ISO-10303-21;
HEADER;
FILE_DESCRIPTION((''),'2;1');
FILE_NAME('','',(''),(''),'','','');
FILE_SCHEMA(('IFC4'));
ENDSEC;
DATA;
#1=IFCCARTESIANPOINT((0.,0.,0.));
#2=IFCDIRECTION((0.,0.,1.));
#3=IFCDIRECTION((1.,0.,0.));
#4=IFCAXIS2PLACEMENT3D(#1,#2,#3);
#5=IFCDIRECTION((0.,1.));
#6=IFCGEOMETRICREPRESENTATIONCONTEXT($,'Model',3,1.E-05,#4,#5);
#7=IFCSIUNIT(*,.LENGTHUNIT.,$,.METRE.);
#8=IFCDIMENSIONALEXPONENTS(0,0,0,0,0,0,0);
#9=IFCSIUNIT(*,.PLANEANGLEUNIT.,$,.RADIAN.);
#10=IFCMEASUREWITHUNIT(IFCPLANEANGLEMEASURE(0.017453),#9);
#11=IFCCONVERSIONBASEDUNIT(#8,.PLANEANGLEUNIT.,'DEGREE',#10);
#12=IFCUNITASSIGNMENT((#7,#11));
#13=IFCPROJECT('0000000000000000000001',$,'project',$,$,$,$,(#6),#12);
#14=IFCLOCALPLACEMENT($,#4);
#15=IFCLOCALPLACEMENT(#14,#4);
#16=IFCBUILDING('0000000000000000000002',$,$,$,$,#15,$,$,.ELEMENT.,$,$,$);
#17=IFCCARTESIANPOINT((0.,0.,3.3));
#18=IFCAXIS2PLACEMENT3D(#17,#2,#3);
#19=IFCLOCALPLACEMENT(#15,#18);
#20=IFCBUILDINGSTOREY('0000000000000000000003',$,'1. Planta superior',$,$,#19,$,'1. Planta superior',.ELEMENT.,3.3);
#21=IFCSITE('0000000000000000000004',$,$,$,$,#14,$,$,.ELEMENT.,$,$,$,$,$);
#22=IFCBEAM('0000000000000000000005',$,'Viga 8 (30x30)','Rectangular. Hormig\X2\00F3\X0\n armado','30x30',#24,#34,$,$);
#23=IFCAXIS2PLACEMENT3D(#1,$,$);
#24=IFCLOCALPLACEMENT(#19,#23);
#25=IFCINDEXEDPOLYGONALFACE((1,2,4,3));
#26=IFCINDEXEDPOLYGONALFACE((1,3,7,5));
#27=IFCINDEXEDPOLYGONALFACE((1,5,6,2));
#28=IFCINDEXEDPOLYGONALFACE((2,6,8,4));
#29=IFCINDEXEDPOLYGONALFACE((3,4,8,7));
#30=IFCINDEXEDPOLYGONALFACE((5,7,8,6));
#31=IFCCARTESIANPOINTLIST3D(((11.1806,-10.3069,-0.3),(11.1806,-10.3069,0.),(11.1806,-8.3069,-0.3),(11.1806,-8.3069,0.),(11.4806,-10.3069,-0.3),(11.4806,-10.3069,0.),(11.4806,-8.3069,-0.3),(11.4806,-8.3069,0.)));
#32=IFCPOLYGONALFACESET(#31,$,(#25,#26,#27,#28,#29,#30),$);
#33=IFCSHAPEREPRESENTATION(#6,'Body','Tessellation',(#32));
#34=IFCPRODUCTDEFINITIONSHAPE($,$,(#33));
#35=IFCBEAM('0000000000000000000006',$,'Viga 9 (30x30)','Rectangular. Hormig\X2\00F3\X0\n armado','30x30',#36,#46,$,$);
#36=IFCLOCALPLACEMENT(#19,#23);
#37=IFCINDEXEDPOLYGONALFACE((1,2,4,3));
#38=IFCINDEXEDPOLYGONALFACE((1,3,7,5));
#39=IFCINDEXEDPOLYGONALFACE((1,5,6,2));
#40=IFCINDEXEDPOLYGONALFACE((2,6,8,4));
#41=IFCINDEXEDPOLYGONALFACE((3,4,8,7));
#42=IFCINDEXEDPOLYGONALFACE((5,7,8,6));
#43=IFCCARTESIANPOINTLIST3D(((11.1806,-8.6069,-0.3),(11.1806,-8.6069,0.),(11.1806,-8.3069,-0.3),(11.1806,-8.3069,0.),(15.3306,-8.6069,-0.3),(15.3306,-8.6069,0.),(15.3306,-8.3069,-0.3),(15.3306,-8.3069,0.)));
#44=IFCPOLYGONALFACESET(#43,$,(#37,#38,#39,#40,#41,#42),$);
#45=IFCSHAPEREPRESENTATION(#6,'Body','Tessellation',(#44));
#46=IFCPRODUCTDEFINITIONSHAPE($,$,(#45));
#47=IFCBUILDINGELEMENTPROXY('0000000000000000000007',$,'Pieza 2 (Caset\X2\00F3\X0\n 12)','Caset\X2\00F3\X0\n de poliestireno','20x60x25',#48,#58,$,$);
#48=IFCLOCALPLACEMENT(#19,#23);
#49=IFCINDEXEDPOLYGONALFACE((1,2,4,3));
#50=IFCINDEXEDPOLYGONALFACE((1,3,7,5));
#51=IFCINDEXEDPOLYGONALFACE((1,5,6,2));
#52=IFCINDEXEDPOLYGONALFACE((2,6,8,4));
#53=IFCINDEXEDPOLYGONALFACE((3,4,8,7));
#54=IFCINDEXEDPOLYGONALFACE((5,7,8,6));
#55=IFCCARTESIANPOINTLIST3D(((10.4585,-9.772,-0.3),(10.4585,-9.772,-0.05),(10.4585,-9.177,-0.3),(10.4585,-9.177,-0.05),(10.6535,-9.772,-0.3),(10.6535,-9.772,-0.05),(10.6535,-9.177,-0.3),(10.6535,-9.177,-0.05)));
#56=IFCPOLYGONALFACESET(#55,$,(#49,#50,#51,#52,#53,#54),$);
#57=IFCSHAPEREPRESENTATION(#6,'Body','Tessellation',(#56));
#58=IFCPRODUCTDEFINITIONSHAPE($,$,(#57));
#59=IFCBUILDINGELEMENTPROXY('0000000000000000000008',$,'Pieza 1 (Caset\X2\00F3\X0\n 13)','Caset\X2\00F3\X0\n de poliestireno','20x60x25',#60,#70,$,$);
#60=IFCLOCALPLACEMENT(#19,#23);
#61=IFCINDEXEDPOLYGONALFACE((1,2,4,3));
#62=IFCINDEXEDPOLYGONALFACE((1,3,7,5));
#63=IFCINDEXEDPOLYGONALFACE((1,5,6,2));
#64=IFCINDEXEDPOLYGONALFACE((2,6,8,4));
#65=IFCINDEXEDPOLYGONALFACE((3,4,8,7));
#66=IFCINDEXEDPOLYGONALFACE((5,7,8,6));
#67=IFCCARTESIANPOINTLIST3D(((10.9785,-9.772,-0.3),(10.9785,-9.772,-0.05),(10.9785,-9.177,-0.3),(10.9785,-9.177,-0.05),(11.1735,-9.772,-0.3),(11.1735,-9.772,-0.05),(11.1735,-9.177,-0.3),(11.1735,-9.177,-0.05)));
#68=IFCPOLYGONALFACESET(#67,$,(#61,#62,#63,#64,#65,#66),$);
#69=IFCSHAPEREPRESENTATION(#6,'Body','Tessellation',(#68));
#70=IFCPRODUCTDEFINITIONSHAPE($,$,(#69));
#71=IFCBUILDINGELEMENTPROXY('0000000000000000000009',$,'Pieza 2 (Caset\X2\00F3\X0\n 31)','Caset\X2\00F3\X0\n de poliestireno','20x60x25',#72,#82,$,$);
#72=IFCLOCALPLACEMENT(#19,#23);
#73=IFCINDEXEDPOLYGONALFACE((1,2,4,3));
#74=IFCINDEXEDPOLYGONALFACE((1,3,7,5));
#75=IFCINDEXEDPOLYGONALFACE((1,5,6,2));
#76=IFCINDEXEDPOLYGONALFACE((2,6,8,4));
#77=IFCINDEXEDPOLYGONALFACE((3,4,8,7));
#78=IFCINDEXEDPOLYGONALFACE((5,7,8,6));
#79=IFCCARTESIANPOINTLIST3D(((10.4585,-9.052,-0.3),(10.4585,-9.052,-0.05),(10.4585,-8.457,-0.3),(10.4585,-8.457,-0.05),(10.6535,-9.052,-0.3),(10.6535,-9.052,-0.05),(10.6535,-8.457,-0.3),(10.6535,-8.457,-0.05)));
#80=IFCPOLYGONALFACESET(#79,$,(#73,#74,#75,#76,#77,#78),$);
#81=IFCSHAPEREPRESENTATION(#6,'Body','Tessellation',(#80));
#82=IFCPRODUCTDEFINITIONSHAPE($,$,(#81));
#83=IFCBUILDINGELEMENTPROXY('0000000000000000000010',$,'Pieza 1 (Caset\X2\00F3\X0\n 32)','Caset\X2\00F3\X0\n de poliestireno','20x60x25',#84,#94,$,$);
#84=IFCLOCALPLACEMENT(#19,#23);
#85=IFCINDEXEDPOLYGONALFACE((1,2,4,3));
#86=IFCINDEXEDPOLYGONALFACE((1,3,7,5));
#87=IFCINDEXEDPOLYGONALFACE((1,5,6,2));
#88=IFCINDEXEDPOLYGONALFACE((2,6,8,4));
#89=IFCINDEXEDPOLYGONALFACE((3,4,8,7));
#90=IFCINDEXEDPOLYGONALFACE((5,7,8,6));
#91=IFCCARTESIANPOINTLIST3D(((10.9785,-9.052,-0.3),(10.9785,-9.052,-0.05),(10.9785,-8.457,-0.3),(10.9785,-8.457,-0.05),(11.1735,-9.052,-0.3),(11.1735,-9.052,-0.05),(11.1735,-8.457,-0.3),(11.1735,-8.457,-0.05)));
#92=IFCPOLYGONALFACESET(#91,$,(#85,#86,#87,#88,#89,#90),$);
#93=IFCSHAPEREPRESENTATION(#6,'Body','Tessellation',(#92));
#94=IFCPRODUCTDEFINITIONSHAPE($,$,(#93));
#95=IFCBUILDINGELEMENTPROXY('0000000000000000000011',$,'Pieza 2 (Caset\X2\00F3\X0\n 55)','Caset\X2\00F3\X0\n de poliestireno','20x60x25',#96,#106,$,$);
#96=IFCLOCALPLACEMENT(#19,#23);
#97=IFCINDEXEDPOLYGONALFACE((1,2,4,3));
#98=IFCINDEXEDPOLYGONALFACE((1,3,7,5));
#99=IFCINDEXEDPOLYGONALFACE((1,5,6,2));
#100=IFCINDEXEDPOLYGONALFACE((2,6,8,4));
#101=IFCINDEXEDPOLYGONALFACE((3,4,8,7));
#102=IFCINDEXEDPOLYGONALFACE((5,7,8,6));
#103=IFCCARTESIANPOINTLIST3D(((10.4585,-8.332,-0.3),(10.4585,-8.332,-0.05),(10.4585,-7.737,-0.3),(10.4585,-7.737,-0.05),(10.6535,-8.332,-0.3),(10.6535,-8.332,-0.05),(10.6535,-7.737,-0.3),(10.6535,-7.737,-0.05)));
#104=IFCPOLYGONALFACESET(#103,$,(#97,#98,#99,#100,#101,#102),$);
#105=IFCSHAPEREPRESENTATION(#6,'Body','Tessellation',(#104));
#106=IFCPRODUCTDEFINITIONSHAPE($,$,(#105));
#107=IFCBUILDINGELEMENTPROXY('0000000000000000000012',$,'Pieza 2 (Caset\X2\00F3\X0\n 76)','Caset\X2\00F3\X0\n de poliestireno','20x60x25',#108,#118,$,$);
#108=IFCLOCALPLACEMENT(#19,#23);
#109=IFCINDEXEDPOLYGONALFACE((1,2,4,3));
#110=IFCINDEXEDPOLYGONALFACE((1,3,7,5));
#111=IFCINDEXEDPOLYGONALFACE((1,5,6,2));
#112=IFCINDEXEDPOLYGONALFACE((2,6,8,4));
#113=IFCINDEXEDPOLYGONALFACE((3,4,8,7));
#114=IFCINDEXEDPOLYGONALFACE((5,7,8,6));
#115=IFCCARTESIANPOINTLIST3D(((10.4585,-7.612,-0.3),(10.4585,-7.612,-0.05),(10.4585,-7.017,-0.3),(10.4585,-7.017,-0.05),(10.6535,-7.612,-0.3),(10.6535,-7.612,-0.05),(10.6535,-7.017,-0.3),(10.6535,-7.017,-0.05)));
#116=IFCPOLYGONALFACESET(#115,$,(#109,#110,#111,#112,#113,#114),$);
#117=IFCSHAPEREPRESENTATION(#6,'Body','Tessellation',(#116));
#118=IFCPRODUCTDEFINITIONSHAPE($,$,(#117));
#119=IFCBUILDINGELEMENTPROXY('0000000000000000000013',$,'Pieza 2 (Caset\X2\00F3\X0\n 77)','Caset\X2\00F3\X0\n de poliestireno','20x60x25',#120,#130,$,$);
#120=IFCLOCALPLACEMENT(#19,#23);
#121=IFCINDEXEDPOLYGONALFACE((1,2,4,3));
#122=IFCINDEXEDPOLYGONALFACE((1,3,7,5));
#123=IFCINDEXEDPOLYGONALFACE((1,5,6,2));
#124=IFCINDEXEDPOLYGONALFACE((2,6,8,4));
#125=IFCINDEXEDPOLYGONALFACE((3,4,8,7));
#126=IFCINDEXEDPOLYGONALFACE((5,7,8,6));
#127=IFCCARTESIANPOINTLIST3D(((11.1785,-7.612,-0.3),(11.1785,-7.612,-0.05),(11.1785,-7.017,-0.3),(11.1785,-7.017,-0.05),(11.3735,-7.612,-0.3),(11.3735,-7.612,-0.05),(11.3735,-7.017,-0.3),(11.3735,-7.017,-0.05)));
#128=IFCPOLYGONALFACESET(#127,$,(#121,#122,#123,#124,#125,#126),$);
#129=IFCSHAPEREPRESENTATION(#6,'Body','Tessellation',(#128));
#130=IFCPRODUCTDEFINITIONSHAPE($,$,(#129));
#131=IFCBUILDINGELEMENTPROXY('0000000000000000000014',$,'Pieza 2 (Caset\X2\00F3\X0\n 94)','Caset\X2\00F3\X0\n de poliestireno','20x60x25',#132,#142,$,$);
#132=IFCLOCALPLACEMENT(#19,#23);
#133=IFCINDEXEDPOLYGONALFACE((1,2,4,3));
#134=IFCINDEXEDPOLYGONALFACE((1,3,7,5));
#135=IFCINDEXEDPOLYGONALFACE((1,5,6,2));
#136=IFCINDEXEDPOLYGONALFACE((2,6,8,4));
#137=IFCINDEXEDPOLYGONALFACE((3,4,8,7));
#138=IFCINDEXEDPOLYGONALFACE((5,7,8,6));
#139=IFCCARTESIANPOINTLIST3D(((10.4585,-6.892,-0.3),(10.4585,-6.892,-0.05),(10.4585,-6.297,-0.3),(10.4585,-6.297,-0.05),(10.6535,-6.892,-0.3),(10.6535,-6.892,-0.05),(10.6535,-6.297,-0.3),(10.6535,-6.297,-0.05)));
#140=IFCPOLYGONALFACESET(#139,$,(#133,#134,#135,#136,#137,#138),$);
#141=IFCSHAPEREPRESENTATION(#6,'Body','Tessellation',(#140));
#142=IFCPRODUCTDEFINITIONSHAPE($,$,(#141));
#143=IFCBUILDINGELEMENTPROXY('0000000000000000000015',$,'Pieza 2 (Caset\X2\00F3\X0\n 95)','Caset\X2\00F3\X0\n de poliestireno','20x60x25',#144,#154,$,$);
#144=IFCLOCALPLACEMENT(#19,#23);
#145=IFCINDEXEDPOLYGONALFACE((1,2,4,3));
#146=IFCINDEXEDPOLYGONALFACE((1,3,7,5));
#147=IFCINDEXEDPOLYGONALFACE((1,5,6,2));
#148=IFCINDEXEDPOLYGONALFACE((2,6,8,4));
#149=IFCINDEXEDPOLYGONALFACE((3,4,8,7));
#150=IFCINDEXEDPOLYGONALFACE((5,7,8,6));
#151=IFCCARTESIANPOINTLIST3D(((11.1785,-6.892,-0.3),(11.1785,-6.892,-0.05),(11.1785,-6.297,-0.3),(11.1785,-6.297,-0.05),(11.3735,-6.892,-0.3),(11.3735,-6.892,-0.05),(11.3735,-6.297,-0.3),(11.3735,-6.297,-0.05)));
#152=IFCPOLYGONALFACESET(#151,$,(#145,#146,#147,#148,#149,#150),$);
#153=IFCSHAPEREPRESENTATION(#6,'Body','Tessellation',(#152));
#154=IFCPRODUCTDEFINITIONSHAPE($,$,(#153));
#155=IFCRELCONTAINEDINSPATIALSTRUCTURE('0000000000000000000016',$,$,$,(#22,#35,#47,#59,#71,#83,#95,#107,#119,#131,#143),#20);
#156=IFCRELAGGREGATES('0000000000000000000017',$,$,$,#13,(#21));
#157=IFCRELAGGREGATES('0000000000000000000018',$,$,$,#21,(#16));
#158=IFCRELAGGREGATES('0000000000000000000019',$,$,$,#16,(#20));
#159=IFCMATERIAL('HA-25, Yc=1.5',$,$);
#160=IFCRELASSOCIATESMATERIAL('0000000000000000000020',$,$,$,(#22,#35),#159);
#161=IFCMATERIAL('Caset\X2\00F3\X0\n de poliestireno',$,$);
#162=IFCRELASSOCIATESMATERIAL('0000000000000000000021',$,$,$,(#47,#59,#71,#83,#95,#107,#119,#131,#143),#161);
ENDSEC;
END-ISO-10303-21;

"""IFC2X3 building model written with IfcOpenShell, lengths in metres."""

from ifc_helpers import new_model, entity, si_unit, converted_unit, direction, frame, frame_2d, origin_with_axes, origin_2d_with_axis, place, context, project, spatial, rectangle, extrude, source, transform, mapped, material, element, save


model = new_model("IFC2X3")

# Units and contexts
model_context = context("Model", 3, precision=1e-05, world=origin_with_axes(), true_north=direction((0.0, 1.0)))
ifc_project = project(units=[si_unit("LENGTHUNIT", "METRE"), converted_unit("PLANEANGLEUNIT", "DEGREE", entity("IfcPlaneAngleMeasure", 0.017453), si_unit("PLANEANGLEUNIT", "RADIAN"), dimensions=[0, 0, 0, 0, 0, 0, 0])], contexts=[model_context])

# Site, building, storey
site_placement = place(None, origin_with_axes())
site = spatial("IfcSite", under=ifc_project, at=site_placement, CompositionType="ELEMENT")
building_placement = place(site_placement, origin_with_axes())
building = spatial("IfcBuilding", under=site, at=building_placement, CompositionType="ELEMENT")
storey_placement = place(building_placement, frame((0.0, 0.0, 3.3), z_axis=(0.0, 0.0, 1.0), x_axis=(1.0, 0.0, 0.0)))
storey = spatial("IfcBuildingStorey", under=building, at=storey_placement, Name="1. Planta superior", LongName="1. Planta superior", CompositionType="ELEMENT", Elevation=3.3)

# Beams
ifc_material_1 = material(Name="HA-25, Yc=1.5")
beam_1_placement = place(storey_placement, frame((11.3306, -10.3069, 0.0), z_axis=(0.0, 1.0, 0.0), x_axis=(-1.0, 0.0, 0.0)))
element("IfcBeam", 1, at=beam_1_placement, inside=storey, material=ifc_material_1, Name="Viga 8 (30x30)", Description="Rectangular. Hormigón armado", ObjectType="30x30", context=model_context, shape_type="SweptSolid", body=[
    extrude(rectangle(XDim=0.3, YDim=0.3, at=frame_2d((0.0, -0.15), x_axis=(1.0, 0.0))), origin_with_axes(), (0.0, 0.0, 1.0), 2.0),
])
beam_2_placement = place(storey_placement, frame((11.1806, -8.4569, 0.0), z_axis=(1.0, 0.0, 0.0), x_axis=(0.0, 1.0, 0.0)))
element("IfcBeam", 2, at=beam_2_placement, inside=storey, material=ifc_material_1, Name="Viga 9 (30x30)", Description="Rectangular. Hormigón armado", ObjectType="30x30", context=model_context, shape_type="SweptSolid", body=[
    extrude(rectangle(XDim=0.3, YDim=0.3, at=frame_2d((0.0, -0.15), x_axis=(1.0, 0.0))), origin_with_axes(), (0.0, 0.0, 1.0), 4.15),
])

# Building element proxies
ifc_material_2 = material(Name="Casetón de poliestireno")
shared_shape = source(origin_with_axes(), model_context, "Body", "SweptSolid", [
    extrude(rectangle(XDim=0.195, YDim=0.25, at=origin_2d_with_axis()), origin_with_axes(), (0.0, 0.0, 1.0), 0.595),
])
placement_1 = place(storey_placement, frame((10.556, -9.772, -0.175), z_axis=(0.0, 1.0, 0.0), x_axis=(-1.0, 0.0, 0.0)))
for number, where, z_axis, x_axis, name in (
    (3, (0.0, 0.0, 0.0), (0.0, 0.0, 1.0), (1.0, 0.0, 0.0), "Pieza 2 (Casetón 12)"),
):
    element("IfcBuildingElementProxy", number, at=place(placement_1, frame(where, z_axis=z_axis, x_axis=x_axis)), inside=storey, material=ifc_material_2, Name=name, Description="Casetón de poliestireno", ObjectType="20x60x25", context=model_context, shape_type="MappedRepresentation", body=[
        mapped(shared_shape, transform((0.0, 0.0, 0.0), x_axis=(1.0, 0.0, 0.0), y_axis=(0.0, 1.0, 0.0), z_axis=(0.0, 0.0, 1.0))),
    ])
placement_2 = place(storey_placement, frame((11.076, -9.772, -0.175), z_axis=(0.0, 1.0, 0.0), x_axis=(-1.0, 0.0, 0.0)))
proxy_1_placement = place(placement_2, origin_with_axes())
element("IfcBuildingElementProxy", 4, at=proxy_1_placement, inside=storey, material=ifc_material_2, Name="Pieza 1 (Casetón 13)", Description="Casetón de poliestireno", ObjectType="20x60x25", context=model_context, shape_type="MappedRepresentation", body=[
    mapped(shared_shape, transform((0.0, 0.0, 0.0), x_axis=(1.0, 0.0, 0.0), y_axis=(0.0, 1.0, 0.0), z_axis=(0.0, 0.0, 1.0))),
])
placement_3 = place(storey_placement, frame((10.556, -9.052, -0.175), z_axis=(0.0, 1.0, 0.0), x_axis=(-1.0, 0.0, 0.0)))
for number, where, z_axis, x_axis, name in (
    (5, (0.0, 0.0, 0.0), (0.0, 0.0, 1.0), (1.0, 0.0, 0.0), "Pieza 2 (Casetón 31)"),
):
    element("IfcBuildingElementProxy", number, at=place(placement_3, frame(where, z_axis=z_axis, x_axis=x_axis)), inside=storey, material=ifc_material_2, Name=name, Description="Casetón de poliestireno", ObjectType="20x60x25", context=model_context, shape_type="MappedRepresentation", body=[
        mapped(shared_shape, transform((0.0, 0.0, 0.0), x_axis=(1.0, 0.0, 0.0), y_axis=(0.0, 1.0, 0.0), z_axis=(0.0, 0.0, 1.0))),
    ])
placement_4 = place(storey_placement, frame((11.076, -9.052, -0.175), z_axis=(0.0, 1.0, 0.0), x_axis=(-1.0, 0.0, 0.0)))
proxy_2_placement = place(placement_4, origin_with_axes())
element("IfcBuildingElementProxy", 6, at=proxy_2_placement, inside=storey, material=ifc_material_2, Name="Pieza 1 (Casetón 32)", Description="Casetón de poliestireno", ObjectType="20x60x25", context=model_context, shape_type="MappedRepresentation", body=[
    mapped(shared_shape, transform((0.0, 0.0, 0.0), x_axis=(1.0, 0.0, 0.0), y_axis=(0.0, 1.0, 0.0), z_axis=(0.0, 0.0, 1.0))),
])
placement_5 = place(storey_placement, frame((10.556, -8.332, -0.175), z_axis=(0.0, 1.0, 0.0), x_axis=(-1.0, 0.0, 0.0)))
for number, where, z_axis, x_axis, name in (
    (7, (0.0, 0.0, 0.0), (0.0, 0.0, 1.0), (1.0, 0.0, 0.0), "Pieza 2 (Casetón 55)"),
):
    element("IfcBuildingElementProxy", number, at=place(placement_5, frame(where, z_axis=z_axis, x_axis=x_axis)), inside=storey, material=ifc_material_2, Name=name, Description="Casetón de poliestireno", ObjectType="20x60x25", context=model_context, shape_type="MappedRepresentation", body=[
        mapped(shared_shape, transform((0.0, 0.0, 0.0), x_axis=(1.0, 0.0, 0.0), y_axis=(0.0, 1.0, 0.0), z_axis=(0.0, 0.0, 1.0))),
    ])
placement_6 = place(storey_placement, frame((10.556, -7.612, -0.175), z_axis=(0.0, 1.0, 0.0), x_axis=(-1.0, 0.0, 0.0)))
for number, where, z_axis, x_axis, name in (
    (8, (0.0, 0.0, 0.0), (0.0, 0.0, 1.0), (1.0, 0.0, 0.0), "Pieza 2 (Casetón 76)"),
):
    element("IfcBuildingElementProxy", number, at=place(placement_6, frame(where, z_axis=z_axis, x_axis=x_axis)), inside=storey, material=ifc_material_2, Name=name, Description="Casetón de poliestireno", ObjectType="20x60x25", context=model_context, shape_type="MappedRepresentation", body=[
        mapped(shared_shape, transform((0.0, 0.0, 0.0), x_axis=(1.0, 0.0, 0.0), y_axis=(0.0, 1.0, 0.0), z_axis=(0.0, 0.0, 1.0))),
    ])
placement_7 = place(storey_placement, frame((11.276, -7.612, -0.175), z_axis=(0.0, 1.0, 0.0), x_axis=(-1.0, 0.0, 0.0)))
for number, where, z_axis, x_axis, name in (
    (9, (0.0, 0.0, 0.0), (0.0, 0.0, 1.0), (1.0, 0.0, 0.0), "Pieza 2 (Casetón 77)"),
):
    element("IfcBuildingElementProxy", number, at=place(placement_7, frame(where, z_axis=z_axis, x_axis=x_axis)), inside=storey, material=ifc_material_2, Name=name, Description="Casetón de poliestireno", ObjectType="20x60x25", context=model_context, shape_type="MappedRepresentation", body=[
        mapped(shared_shape, transform((0.0, 0.0, 0.0), x_axis=(1.0, 0.0, 0.0), y_axis=(0.0, 1.0, 0.0), z_axis=(0.0, 0.0, 1.0))),
    ])
placement_8 = place(storey_placement, frame((10.556, -6.892, -0.175), z_axis=(0.0, 1.0, 0.0), x_axis=(-1.0, 0.0, 0.0)))
for number, where, z_axis, x_axis, name in (
    (10, (0.0, 0.0, 0.0), (0.0, 0.0, 1.0), (1.0, 0.0, 0.0), "Pieza 2 (Casetón 94)"),
):
    element("IfcBuildingElementProxy", number, at=place(placement_8, frame(where, z_axis=z_axis, x_axis=x_axis)), inside=storey, material=ifc_material_2, Name=name, Description="Casetón de poliestireno", ObjectType="20x60x25", context=model_context, shape_type="MappedRepresentation", body=[
        mapped(shared_shape, transform((0.0, 0.0, 0.0), x_axis=(1.0, 0.0, 0.0), y_axis=(0.0, 1.0, 0.0), z_axis=(0.0, 0.0, 1.0))),
    ])
placement_9 = place(storey_placement, frame((11.276, -6.892, -0.175), z_axis=(0.0, 1.0, 0.0), x_axis=(-1.0, 0.0, 0.0)))
for number, where, z_axis, x_axis, name in (
    (11, (0.0, 0.0, 0.0), (0.0, 0.0, 1.0), (1.0, 0.0, 0.0), "Pieza 2 (Casetón 95)"),
):
    element("IfcBuildingElementProxy", number, at=place(placement_9, frame(where, z_axis=z_axis, x_axis=x_axis)), inside=storey, material=ifc_material_2, Name=name, Description="Casetón de poliestireno", ObjectType="20x60x25", context=model_context, shape_type="MappedRepresentation", body=[
        mapped(shared_shape, transform((0.0, 0.0, 0.0), x_axis=(1.0, 0.0, 0.0), y_axis=(0.0, 1.0, 0.0), z_axis=(0.0, 0.0, 1.0))),
    ])

save(model, "model.ifc")
